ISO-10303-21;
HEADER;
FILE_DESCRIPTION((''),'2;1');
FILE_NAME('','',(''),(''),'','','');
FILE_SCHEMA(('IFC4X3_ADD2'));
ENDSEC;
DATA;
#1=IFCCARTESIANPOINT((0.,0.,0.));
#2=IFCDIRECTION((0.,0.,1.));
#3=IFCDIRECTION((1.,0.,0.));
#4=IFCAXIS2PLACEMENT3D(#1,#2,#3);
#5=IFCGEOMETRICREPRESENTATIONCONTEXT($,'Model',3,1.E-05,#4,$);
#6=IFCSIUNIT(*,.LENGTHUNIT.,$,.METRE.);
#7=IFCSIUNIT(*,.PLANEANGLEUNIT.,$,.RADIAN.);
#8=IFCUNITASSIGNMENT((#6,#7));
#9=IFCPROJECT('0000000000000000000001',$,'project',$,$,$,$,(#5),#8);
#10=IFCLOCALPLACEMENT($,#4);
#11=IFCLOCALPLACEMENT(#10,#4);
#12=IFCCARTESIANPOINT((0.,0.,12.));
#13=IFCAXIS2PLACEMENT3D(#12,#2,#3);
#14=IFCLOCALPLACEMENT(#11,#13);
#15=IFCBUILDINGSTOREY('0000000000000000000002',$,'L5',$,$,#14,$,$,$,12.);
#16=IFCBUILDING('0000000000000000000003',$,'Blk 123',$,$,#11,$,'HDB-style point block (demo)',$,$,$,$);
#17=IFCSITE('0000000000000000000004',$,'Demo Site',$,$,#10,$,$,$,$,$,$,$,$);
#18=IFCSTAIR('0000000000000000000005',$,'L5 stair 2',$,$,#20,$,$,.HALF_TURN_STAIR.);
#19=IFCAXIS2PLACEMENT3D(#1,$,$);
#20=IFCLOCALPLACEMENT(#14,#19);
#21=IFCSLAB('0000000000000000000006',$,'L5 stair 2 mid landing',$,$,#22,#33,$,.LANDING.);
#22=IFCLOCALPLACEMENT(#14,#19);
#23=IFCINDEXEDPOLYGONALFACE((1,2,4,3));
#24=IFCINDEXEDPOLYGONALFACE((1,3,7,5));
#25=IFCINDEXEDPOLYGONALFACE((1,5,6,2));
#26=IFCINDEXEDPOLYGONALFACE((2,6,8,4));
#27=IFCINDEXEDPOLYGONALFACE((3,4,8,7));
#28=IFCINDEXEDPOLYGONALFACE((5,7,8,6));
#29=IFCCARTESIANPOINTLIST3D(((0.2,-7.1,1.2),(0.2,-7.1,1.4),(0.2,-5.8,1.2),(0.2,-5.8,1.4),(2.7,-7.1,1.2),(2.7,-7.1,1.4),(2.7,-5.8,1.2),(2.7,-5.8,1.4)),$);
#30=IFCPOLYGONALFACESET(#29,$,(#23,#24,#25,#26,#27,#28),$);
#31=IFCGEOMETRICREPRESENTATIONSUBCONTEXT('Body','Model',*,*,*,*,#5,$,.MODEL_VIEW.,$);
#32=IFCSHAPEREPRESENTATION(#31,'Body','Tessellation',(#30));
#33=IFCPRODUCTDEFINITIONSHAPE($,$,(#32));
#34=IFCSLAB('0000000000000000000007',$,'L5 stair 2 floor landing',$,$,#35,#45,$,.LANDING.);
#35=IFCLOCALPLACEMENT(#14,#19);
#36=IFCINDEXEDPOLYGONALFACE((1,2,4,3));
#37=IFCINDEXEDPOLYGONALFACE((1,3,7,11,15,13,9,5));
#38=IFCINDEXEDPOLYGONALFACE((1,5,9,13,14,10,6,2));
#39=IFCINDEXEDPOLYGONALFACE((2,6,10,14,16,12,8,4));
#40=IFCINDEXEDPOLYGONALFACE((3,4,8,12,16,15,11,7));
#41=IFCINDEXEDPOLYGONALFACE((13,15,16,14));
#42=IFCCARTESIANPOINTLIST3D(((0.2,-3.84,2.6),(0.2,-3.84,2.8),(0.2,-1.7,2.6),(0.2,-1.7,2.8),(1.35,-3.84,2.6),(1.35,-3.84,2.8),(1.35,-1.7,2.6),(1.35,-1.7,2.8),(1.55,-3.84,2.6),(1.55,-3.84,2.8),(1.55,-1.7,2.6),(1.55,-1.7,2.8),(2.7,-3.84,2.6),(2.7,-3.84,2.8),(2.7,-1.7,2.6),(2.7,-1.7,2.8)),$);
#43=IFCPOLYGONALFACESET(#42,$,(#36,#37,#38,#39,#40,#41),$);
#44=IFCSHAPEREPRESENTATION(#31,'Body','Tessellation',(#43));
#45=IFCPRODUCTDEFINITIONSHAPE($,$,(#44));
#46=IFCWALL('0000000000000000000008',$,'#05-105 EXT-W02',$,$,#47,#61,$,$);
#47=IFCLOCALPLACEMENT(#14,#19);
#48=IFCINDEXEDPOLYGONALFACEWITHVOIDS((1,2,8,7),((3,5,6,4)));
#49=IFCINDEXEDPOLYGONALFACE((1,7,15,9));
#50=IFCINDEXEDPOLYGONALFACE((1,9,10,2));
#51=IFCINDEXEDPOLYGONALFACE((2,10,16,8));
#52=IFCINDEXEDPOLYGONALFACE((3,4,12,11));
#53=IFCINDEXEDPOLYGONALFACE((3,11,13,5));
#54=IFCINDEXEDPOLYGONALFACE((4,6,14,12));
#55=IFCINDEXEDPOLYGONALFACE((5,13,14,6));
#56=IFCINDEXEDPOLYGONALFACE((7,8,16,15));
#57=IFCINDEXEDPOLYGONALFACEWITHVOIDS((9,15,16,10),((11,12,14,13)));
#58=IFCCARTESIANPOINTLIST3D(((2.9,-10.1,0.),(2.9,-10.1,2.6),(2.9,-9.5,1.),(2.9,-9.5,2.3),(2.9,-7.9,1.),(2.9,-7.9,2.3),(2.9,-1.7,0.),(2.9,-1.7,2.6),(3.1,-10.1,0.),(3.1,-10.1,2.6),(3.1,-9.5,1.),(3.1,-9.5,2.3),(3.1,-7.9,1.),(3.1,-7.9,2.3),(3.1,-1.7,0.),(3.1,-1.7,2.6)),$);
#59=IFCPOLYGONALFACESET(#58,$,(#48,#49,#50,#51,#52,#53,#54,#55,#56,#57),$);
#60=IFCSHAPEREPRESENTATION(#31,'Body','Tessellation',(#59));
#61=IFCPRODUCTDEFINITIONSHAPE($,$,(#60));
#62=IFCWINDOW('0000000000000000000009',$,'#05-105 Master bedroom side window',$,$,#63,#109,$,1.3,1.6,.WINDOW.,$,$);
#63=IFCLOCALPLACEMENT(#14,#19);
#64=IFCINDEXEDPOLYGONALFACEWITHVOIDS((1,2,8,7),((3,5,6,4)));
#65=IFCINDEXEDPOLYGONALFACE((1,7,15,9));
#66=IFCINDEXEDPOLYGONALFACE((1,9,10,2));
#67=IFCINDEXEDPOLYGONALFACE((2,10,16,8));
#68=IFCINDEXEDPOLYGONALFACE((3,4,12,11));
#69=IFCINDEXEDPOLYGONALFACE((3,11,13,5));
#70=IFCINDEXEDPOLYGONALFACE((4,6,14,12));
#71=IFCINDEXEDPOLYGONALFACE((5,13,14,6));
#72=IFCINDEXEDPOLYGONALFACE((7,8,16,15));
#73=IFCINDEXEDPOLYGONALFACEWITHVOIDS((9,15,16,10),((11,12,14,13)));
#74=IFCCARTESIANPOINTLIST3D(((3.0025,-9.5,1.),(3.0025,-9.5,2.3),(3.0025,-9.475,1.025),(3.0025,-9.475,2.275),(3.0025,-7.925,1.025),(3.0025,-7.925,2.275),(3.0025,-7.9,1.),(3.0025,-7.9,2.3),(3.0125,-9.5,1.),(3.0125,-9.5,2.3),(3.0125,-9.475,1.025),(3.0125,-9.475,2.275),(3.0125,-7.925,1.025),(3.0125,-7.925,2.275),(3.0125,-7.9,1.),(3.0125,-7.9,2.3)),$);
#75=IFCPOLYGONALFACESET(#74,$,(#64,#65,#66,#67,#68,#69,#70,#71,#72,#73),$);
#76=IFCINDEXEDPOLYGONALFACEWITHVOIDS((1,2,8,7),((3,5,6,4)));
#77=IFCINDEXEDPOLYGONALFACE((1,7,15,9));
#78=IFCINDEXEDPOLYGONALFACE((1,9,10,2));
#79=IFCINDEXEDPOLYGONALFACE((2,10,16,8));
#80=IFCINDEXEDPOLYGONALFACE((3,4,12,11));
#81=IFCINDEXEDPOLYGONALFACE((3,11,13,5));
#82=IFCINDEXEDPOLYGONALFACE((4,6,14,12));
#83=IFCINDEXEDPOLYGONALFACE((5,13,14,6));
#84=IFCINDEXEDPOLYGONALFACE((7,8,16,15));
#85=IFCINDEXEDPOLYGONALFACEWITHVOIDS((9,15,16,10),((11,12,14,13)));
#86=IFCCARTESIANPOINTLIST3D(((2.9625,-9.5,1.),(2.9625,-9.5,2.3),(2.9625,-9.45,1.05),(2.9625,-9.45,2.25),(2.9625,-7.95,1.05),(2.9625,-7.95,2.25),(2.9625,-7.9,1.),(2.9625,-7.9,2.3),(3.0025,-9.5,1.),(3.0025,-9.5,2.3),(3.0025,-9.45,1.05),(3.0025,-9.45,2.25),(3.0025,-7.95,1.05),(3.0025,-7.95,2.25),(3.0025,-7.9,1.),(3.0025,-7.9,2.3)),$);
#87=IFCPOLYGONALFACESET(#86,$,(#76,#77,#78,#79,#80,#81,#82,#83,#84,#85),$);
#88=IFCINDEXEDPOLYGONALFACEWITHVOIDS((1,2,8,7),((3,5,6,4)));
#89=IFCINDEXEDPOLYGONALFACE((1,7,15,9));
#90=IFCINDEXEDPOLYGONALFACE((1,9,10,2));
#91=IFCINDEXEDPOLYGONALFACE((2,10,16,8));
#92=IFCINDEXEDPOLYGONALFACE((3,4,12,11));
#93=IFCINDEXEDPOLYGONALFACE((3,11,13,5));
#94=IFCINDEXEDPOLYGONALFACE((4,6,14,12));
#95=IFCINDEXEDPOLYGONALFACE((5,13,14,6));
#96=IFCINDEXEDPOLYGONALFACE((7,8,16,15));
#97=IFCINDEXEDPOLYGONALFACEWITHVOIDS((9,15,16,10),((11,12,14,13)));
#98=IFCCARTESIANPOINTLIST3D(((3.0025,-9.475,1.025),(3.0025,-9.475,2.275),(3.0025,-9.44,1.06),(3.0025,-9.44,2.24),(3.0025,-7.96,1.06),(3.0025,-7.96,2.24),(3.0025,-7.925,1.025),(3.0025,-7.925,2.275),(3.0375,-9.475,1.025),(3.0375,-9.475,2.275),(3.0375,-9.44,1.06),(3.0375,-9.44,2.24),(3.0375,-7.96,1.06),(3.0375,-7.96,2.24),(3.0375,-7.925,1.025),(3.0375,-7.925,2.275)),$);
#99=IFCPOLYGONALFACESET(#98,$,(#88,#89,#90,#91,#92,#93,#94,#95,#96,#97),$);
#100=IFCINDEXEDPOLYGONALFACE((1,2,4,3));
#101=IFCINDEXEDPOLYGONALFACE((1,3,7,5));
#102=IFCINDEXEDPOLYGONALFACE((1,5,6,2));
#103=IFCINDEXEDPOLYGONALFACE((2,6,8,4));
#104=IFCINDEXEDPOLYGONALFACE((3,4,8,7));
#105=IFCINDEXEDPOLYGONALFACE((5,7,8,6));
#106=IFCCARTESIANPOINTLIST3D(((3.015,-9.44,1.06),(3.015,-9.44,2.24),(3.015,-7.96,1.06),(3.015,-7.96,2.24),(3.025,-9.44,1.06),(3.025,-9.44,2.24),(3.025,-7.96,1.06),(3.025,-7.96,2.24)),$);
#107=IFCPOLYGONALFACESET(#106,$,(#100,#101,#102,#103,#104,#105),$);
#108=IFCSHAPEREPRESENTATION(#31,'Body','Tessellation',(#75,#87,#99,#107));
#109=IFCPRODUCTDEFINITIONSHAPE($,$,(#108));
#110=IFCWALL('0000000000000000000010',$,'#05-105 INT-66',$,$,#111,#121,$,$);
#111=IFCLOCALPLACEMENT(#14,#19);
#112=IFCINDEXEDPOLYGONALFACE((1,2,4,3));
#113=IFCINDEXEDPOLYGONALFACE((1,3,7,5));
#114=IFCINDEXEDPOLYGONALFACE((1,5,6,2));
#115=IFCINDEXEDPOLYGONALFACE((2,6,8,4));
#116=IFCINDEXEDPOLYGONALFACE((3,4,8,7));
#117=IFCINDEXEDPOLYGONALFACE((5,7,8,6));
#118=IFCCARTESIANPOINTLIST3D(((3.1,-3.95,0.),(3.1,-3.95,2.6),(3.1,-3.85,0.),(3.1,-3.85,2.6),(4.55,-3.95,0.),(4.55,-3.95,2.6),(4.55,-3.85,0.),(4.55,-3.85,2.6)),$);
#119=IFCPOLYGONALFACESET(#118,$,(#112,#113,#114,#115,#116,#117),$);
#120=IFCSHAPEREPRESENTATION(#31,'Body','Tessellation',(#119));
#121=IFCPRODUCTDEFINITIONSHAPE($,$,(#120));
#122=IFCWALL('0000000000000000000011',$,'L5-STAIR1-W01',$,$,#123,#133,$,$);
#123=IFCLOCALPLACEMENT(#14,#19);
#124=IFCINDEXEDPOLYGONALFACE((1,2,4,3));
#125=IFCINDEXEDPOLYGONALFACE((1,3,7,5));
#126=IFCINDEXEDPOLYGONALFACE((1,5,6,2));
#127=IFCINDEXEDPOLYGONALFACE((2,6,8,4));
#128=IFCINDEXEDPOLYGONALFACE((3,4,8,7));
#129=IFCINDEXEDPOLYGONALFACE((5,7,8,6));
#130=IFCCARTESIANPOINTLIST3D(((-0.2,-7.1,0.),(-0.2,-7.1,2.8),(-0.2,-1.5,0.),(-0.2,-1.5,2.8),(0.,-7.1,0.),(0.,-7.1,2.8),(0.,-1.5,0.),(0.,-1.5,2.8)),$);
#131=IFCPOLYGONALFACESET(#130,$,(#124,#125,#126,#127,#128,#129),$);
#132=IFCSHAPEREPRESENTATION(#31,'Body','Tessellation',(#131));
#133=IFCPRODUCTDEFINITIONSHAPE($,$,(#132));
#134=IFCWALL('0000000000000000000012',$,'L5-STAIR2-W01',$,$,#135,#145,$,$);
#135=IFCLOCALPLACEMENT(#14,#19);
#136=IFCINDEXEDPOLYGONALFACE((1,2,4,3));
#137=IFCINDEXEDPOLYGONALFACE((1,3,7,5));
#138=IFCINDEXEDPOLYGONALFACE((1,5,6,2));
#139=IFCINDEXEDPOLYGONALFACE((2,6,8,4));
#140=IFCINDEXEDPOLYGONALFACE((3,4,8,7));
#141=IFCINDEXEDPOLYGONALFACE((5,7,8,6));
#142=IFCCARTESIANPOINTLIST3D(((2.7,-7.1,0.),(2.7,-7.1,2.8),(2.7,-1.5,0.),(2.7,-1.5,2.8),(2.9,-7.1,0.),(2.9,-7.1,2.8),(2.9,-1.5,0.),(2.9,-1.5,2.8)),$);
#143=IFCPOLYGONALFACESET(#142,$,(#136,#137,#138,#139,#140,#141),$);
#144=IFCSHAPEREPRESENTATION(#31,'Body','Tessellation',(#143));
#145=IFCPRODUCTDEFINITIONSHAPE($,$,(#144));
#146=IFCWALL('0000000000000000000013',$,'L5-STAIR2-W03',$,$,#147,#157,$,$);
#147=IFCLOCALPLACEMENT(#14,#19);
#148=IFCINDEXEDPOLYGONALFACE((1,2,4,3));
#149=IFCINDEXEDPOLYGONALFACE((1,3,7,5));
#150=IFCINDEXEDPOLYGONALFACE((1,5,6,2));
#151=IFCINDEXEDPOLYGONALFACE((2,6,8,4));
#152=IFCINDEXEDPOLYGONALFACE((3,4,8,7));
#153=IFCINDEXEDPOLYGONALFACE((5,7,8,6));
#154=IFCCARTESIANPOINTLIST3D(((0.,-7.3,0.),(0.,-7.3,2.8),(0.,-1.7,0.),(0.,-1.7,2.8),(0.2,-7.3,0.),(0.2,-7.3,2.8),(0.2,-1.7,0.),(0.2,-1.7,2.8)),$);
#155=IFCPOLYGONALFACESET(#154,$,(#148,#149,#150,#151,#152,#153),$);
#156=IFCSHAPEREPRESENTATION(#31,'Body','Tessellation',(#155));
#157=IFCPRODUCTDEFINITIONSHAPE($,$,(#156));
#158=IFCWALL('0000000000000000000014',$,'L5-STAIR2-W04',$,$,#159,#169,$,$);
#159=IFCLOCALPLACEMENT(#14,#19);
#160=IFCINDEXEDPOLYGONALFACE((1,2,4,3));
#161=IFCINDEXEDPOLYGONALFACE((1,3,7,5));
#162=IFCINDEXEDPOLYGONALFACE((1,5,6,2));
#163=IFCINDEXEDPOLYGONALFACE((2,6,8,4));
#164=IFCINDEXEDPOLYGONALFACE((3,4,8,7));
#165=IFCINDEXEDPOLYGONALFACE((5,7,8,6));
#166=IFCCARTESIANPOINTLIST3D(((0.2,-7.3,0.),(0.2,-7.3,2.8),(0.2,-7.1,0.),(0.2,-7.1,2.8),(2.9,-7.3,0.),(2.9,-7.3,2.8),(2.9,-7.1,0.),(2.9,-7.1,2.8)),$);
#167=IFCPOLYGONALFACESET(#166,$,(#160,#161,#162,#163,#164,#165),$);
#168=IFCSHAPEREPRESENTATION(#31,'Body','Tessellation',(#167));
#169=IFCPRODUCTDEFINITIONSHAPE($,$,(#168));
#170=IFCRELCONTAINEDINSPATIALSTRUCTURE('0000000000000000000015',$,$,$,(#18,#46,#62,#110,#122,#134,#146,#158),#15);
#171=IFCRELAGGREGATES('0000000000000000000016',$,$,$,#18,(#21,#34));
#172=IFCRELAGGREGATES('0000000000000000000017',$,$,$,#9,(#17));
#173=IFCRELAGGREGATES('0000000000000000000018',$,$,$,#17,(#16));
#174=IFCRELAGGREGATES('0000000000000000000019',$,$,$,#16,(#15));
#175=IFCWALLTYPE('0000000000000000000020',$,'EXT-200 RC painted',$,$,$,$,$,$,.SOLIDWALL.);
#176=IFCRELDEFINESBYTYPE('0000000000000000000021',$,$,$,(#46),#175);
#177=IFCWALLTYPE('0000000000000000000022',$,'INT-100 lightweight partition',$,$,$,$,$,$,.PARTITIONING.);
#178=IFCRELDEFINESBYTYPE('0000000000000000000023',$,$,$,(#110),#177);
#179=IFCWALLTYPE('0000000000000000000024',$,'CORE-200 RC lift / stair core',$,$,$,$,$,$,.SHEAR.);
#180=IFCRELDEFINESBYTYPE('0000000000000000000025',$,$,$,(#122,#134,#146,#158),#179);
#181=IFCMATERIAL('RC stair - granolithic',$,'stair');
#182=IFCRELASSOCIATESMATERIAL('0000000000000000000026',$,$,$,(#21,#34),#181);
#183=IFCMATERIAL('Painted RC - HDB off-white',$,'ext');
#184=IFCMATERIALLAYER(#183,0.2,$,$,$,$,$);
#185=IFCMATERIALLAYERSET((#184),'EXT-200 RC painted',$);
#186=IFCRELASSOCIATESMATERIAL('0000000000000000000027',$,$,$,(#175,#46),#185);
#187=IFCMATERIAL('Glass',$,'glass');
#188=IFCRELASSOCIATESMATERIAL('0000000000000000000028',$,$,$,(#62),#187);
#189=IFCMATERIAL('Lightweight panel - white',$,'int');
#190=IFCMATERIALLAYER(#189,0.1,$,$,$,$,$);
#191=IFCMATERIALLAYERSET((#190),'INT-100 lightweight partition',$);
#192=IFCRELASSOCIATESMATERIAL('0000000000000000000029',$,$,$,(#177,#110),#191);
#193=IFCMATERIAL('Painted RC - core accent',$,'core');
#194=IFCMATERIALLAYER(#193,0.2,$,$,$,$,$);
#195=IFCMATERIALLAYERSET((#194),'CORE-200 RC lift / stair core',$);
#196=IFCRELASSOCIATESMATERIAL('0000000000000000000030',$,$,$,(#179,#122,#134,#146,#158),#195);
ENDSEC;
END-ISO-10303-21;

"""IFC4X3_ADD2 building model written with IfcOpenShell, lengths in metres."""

from ifc_helpers import new_model, si_unit, frame, origin, origin_with_axes, place, context, subcontext, project, spatial, polyline, line, indexed_curve, outline, extrude, material, layer, layer_set, layer_usage, type_object, element, fill, aggregate, save


model = new_model("IFC4X3_ADD2")

# Units and contexts
model_context = context("Model", 3, precision=1e-05, world=origin_with_axes())
body_context = subcontext(model_context, "Body", "Model", "MODEL_VIEW")
ifc_project = project(units=[si_unit("LENGTHUNIT", "METRE"), si_unit("PLANEANGLEUNIT", "RADIAN")], contexts=[model_context])

# Site, building, storey
site_placement = place(None, origin_with_axes())
site = spatial("IfcSite", under=ifc_project, at=site_placement, Name="Demo Site")
building_placement = place(site_placement, origin_with_axes())
building = spatial("IfcBuilding", under=site, at=building_placement, Name="Blk 123", LongName="HDB-style point block (demo)")
storey_placement = place(building_placement, frame((0.0, 0.0, 12.0), z_axis=(0.0, 0.0, 1.0), x_axis=(1.0, 0.0, 0.0)))
storey = spatial("IfcBuildingStorey", under=building, at=storey_placement, Name="L5", Elevation=12.0)

# Stair, slabs
stair_placement = place(storey_placement, frame((0.2, -7.1, 0.0), z_axis=(0.0, 0.0, 1.0), x_axis=(1.0, 0.0, 0.0)))
stair = element("IfcStair", 1, at=stair_placement, inside=storey, Name="L5 stair 2", PredefinedType="HALF_TURN_STAIR")
ifc_material_1 = material(Name="RC stair - granolithic", Category="stair")
slab_1_placement = place(stair_placement, frame((1.25, 0.65, 1.2), z_axis=(0.0, 0.0, 1.0), x_axis=(1.0, 0.0, 0.0)))
slab_1 = element("IfcSlab", 2, at=slab_1_placement, material=ifc_material_1, Name="L5 stair 2 mid landing", PredefinedType="LANDING", context=body_context, shape_type="SweptSolid", body=[
    extrude(outline(polyline([(1.25, -0.65), (1.25, 0.65), (-1.25, 0.65), (-1.25, -0.65), (1.25, -0.65)])), origin(), (0.0, 0.0, 1.0), 0.2),
])
slab_2_placement = place(stair_placement, frame((1.25, 4.33, 2.6), z_axis=(0.0, 0.0, 1.0), x_axis=(1.0, 0.0, 0.0)))
slab_2 = element("IfcSlab", 3, at=slab_2_placement, material=ifc_material_1, Name="L5 stair 2 floor landing", PredefinedType="LANDING", context=body_context, shape_type="SweptSolid", body=[
    extrude(outline(polyline([(-0.1, 1.07), (-1.25, 1.07), (-1.25, -1.07), (-0.1, -1.07), (0.1, -1.07), (1.25, -1.07), (1.25, 1.07), (0.1, 1.07), (-0.1, 1.07)])), origin(), (0.0, 0.0, 1.0), 0.2),
])

# Wall, opening, window
ifc_material_2 = material(Name="Painted RC - HDB off-white", Category="ext")
ifc_layer_1 = layer(ifc_material_2, 0.2)
ifc_layer_set_1 = layer_set([ifc_layer_1], Name="EXT-200 RC painted")
ifc_layer_usage_1 = layer_usage(ifc_layer_set_1, "AXIS2", "POSITIVE", 0.0)
wall_type_1 = type_object("IfcWallType", Name="EXT-200 RC painted", PredefinedType="SOLIDWALL", material=ifc_layer_set_1)
wall_1_placement = place(storey_placement, frame((2.9, -1.7, 0.0), z_axis=(0.0, 0.0, 1.0), x_axis=(0.0, -1.0, 0.0)))
wall_1 = element("IfcWall", 4, at=wall_1_placement, inside=storey, type_object=wall_type_1, material=ifc_layer_usage_1, Name="#05-105 EXT-W02", context=body_context, shape_type="SweptSolid", body=[
    extrude(outline(indexed_curve([(0.0, 0.0), (0.0, 0.2), (8.4, 0.2), (8.4, 0.0), (0.0, 0.0)], self_intersect=False)), origin_with_axes(), (0.0, 0.0, 1.0), 2.6),
])
opening_1_placement = place(wall_1_placement, frame((6.2, -0.1, 1.0), z_axis=(0.0, 0.0, 1.0), x_axis=(1.0, 0.0, 0.0)))
opening_1 = element("IfcOpeningElement", 5, at=opening_1_placement, cuts=wall_1, context=body_context, shape_type="SweptSolid", body=[
    extrude(outline(indexed_curve([(0.0, 0.0), (0.0, 0.4), (1.6, 0.4), (1.6, 0.0), (0.0, 0.0)], self_intersect=False)), origin_with_axes(), (0.0, 0.0, 1.0), 1.3),
])
ifc_material_3 = material(Name="Glass", Category="glass")
window_1_placement = place(opening_1_placement, frame((0.0, 0.1125, 0.0), z_axis=(0.0, 0.0, 1.0), x_axis=(1.0, 0.0, 0.0)))
window_1 = element("IfcWindow", 6, at=window_1_placement, inside=storey, material=ifc_material_3, Name="#05-105 Master bedroom side window", OverallHeight=1.3, OverallWidth=1.6, PredefinedType="WINDOW", context=body_context, shape_type="SweptSolid", body=[
    extrude(outline(indexed_curve([(0.0, 0.0), (1.6, 0.0), (1.6, 1.3), (0.0, 1.3)], segments=[line(1, 2, 3, 4, 1)]), holes=[indexed_curve([(0.025, 0.025), (1.575, 0.025), (1.575, 1.275), (0.025, 1.275)], segments=[line(1, 2, 3, 4, 1)])]), frame((0.0, 0.09, 0.0), z_axis=(0.0, -1.0, 0.0), x_axis=(1.0, 0.0, 0.0)), (0.0, 0.0, -1.0), 0.01),
    extrude(outline(indexed_curve([(0.0, 0.0), (1.6, 0.0), (1.6, 1.3), (0.0, 1.3)], segments=[line(1, 2, 3, 4, 1)]), holes=[indexed_curve([(0.05, 0.05), (1.55, 0.05), (1.55, 1.25), (0.05, 1.25)], segments=[line(1, 2, 3, 4, 1)])]), frame((0.0, 0.05, 0.0), z_axis=(0.0, -1.0, 0.0), x_axis=(1.0, 0.0, 0.0)), (0.0, 0.0, -1.0), 0.04),
    extrude(outline(indexed_curve([(0.0, 0.0), (1.55, 0.0), (1.55, 1.25), (0.0, 1.25)], segments=[line(1, 2, 3, 4, 1)]), holes=[indexed_curve([(0.035, 0.035), (1.515, 0.035), (1.515, 1.215), (0.035, 1.215)], segments=[line(1, 2, 3, 4, 1)])]), frame((0.025, 0.09, 0.025), z_axis=(0.0, -1.0, 0.0), x_axis=(1.0, 0.0, 0.0)), (0.0, 0.0, -1.0), 0.035),
    extrude(outline(indexed_curve([(0.035, 0.035), (1.515, 0.035), (1.515, 1.215), (0.035, 1.215)], segments=[line(1, 2, 3, 4, 1)])), frame((0.025, 0.1025, 0.025), z_axis=(0.0, -1.0, 0.0), x_axis=(1.0, 0.0, 0.0)), (0.0, 0.0, -1.0), 0.01),
])
fill(opening_1, window_1)

# Shared definitions
ifc_material_4 = material(Name="Lightweight panel - white", Category="int")
ifc_layer_2 = layer(ifc_material_4, 0.1)
ifc_layer_set_2 = layer_set([ifc_layer_2], Name="INT-100 lightweight partition")
ifc_layer_usage_2 = layer_usage(ifc_layer_set_2, "AXIS2", "POSITIVE", -0.05)
wall_type_2 = type_object("IfcWallType", Name="INT-100 lightweight partition", PredefinedType="PARTITIONING", material=ifc_layer_set_2)

# Wall
wall_2_placement = place(storey_placement, frame((3.1, -3.9, 0.0), z_axis=(0.0, 0.0, 1.0), x_axis=(1.0, 0.0, 0.0)))
element("IfcWall", 7, at=wall_2_placement, inside=storey, type_object=wall_type_2, material=ifc_layer_usage_2, Name="#05-105 INT-66", context=body_context, shape_type="SweptSolid", body=[
    extrude(outline(indexed_curve([(0.0, 0.0), (0.0, 0.1), (1.45, 0.1), (1.45, 0.0), (0.0, 0.0)], self_intersect=False)), frame((0.0, -0.05, 0.0), z_axis=(0.0, 0.0, 1.0), x_axis=(1.0, 0.0, 0.0)), (0.0, 0.0, 1.0), 2.6),
])

# Walls
ifc_material_5 = material(Name="Painted RC - core accent", Category="core")
ifc_layer_3 = layer(ifc_material_5, 0.2)
ifc_layer_set_3 = layer_set([ifc_layer_3], Name="CORE-200 RC lift / stair core")
ifc_layer_usage_3 = layer_usage(ifc_layer_set_3, "AXIS2", "POSITIVE", 0.0)
wall_type_3 = type_object("IfcWallType", Name="CORE-200 RC lift / stair core", PredefinedType="SHEAR", material=ifc_layer_set_3)
for number, where, z_axis, x_axis, name in (
    (8, (0.0, -7.1, 0.0), (0.0, 0.0, 1.0), (0.0, 1.0, 0.0), "L5-STAIR1-W01"),
    (9, (2.9, -7.1, 0.0), (0.0, 0.0, 1.0), (0.0, 1.0, 0.0), "L5-STAIR2-W01"),
    (10, (0.0, -1.7, 0.0), (0.0, 0.0, 1.0), (0.0, -1.0, 0.0), "L5-STAIR2-W03"),
):
    element("IfcWall", number, at=place(storey_placement, frame(where, z_axis=z_axis, x_axis=x_axis)), inside=storey, type_object=wall_type_3, material=ifc_layer_usage_3, Name=name, context=body_context, shape_type="SweptSolid", body=[
        extrude(outline(indexed_curve([(0.0, 0.0), (0.0, 0.2), (5.6, 0.2), (5.6, 0.0), (0.0, 0.0)], self_intersect=False)), origin_with_axes(), (0.0, 0.0, 1.0), 2.8),
    ])
wall_3_placement = place(storey_placement, frame((0.2, -7.3, 0.0), z_axis=(0.0, 0.0, 1.0), x_axis=(1.0, 0.0, 0.0)))
element("IfcWall", 11, at=wall_3_placement, inside=storey, type_object=wall_type_3, material=ifc_layer_usage_3, Name="L5-STAIR2-W04", context=body_context, shape_type="SweptSolid", body=[
    extrude(outline(indexed_curve([(0.0, 0.0), (0.0, 0.2), (2.7, 0.2), (2.7, 0.0), (0.0, 0.0)], self_intersect=False)), origin_with_axes(), (0.0, 0.0, 1.0), 2.8),
])

aggregate(stair, [slab_1, slab_2])

save(model, "model.ifc")
